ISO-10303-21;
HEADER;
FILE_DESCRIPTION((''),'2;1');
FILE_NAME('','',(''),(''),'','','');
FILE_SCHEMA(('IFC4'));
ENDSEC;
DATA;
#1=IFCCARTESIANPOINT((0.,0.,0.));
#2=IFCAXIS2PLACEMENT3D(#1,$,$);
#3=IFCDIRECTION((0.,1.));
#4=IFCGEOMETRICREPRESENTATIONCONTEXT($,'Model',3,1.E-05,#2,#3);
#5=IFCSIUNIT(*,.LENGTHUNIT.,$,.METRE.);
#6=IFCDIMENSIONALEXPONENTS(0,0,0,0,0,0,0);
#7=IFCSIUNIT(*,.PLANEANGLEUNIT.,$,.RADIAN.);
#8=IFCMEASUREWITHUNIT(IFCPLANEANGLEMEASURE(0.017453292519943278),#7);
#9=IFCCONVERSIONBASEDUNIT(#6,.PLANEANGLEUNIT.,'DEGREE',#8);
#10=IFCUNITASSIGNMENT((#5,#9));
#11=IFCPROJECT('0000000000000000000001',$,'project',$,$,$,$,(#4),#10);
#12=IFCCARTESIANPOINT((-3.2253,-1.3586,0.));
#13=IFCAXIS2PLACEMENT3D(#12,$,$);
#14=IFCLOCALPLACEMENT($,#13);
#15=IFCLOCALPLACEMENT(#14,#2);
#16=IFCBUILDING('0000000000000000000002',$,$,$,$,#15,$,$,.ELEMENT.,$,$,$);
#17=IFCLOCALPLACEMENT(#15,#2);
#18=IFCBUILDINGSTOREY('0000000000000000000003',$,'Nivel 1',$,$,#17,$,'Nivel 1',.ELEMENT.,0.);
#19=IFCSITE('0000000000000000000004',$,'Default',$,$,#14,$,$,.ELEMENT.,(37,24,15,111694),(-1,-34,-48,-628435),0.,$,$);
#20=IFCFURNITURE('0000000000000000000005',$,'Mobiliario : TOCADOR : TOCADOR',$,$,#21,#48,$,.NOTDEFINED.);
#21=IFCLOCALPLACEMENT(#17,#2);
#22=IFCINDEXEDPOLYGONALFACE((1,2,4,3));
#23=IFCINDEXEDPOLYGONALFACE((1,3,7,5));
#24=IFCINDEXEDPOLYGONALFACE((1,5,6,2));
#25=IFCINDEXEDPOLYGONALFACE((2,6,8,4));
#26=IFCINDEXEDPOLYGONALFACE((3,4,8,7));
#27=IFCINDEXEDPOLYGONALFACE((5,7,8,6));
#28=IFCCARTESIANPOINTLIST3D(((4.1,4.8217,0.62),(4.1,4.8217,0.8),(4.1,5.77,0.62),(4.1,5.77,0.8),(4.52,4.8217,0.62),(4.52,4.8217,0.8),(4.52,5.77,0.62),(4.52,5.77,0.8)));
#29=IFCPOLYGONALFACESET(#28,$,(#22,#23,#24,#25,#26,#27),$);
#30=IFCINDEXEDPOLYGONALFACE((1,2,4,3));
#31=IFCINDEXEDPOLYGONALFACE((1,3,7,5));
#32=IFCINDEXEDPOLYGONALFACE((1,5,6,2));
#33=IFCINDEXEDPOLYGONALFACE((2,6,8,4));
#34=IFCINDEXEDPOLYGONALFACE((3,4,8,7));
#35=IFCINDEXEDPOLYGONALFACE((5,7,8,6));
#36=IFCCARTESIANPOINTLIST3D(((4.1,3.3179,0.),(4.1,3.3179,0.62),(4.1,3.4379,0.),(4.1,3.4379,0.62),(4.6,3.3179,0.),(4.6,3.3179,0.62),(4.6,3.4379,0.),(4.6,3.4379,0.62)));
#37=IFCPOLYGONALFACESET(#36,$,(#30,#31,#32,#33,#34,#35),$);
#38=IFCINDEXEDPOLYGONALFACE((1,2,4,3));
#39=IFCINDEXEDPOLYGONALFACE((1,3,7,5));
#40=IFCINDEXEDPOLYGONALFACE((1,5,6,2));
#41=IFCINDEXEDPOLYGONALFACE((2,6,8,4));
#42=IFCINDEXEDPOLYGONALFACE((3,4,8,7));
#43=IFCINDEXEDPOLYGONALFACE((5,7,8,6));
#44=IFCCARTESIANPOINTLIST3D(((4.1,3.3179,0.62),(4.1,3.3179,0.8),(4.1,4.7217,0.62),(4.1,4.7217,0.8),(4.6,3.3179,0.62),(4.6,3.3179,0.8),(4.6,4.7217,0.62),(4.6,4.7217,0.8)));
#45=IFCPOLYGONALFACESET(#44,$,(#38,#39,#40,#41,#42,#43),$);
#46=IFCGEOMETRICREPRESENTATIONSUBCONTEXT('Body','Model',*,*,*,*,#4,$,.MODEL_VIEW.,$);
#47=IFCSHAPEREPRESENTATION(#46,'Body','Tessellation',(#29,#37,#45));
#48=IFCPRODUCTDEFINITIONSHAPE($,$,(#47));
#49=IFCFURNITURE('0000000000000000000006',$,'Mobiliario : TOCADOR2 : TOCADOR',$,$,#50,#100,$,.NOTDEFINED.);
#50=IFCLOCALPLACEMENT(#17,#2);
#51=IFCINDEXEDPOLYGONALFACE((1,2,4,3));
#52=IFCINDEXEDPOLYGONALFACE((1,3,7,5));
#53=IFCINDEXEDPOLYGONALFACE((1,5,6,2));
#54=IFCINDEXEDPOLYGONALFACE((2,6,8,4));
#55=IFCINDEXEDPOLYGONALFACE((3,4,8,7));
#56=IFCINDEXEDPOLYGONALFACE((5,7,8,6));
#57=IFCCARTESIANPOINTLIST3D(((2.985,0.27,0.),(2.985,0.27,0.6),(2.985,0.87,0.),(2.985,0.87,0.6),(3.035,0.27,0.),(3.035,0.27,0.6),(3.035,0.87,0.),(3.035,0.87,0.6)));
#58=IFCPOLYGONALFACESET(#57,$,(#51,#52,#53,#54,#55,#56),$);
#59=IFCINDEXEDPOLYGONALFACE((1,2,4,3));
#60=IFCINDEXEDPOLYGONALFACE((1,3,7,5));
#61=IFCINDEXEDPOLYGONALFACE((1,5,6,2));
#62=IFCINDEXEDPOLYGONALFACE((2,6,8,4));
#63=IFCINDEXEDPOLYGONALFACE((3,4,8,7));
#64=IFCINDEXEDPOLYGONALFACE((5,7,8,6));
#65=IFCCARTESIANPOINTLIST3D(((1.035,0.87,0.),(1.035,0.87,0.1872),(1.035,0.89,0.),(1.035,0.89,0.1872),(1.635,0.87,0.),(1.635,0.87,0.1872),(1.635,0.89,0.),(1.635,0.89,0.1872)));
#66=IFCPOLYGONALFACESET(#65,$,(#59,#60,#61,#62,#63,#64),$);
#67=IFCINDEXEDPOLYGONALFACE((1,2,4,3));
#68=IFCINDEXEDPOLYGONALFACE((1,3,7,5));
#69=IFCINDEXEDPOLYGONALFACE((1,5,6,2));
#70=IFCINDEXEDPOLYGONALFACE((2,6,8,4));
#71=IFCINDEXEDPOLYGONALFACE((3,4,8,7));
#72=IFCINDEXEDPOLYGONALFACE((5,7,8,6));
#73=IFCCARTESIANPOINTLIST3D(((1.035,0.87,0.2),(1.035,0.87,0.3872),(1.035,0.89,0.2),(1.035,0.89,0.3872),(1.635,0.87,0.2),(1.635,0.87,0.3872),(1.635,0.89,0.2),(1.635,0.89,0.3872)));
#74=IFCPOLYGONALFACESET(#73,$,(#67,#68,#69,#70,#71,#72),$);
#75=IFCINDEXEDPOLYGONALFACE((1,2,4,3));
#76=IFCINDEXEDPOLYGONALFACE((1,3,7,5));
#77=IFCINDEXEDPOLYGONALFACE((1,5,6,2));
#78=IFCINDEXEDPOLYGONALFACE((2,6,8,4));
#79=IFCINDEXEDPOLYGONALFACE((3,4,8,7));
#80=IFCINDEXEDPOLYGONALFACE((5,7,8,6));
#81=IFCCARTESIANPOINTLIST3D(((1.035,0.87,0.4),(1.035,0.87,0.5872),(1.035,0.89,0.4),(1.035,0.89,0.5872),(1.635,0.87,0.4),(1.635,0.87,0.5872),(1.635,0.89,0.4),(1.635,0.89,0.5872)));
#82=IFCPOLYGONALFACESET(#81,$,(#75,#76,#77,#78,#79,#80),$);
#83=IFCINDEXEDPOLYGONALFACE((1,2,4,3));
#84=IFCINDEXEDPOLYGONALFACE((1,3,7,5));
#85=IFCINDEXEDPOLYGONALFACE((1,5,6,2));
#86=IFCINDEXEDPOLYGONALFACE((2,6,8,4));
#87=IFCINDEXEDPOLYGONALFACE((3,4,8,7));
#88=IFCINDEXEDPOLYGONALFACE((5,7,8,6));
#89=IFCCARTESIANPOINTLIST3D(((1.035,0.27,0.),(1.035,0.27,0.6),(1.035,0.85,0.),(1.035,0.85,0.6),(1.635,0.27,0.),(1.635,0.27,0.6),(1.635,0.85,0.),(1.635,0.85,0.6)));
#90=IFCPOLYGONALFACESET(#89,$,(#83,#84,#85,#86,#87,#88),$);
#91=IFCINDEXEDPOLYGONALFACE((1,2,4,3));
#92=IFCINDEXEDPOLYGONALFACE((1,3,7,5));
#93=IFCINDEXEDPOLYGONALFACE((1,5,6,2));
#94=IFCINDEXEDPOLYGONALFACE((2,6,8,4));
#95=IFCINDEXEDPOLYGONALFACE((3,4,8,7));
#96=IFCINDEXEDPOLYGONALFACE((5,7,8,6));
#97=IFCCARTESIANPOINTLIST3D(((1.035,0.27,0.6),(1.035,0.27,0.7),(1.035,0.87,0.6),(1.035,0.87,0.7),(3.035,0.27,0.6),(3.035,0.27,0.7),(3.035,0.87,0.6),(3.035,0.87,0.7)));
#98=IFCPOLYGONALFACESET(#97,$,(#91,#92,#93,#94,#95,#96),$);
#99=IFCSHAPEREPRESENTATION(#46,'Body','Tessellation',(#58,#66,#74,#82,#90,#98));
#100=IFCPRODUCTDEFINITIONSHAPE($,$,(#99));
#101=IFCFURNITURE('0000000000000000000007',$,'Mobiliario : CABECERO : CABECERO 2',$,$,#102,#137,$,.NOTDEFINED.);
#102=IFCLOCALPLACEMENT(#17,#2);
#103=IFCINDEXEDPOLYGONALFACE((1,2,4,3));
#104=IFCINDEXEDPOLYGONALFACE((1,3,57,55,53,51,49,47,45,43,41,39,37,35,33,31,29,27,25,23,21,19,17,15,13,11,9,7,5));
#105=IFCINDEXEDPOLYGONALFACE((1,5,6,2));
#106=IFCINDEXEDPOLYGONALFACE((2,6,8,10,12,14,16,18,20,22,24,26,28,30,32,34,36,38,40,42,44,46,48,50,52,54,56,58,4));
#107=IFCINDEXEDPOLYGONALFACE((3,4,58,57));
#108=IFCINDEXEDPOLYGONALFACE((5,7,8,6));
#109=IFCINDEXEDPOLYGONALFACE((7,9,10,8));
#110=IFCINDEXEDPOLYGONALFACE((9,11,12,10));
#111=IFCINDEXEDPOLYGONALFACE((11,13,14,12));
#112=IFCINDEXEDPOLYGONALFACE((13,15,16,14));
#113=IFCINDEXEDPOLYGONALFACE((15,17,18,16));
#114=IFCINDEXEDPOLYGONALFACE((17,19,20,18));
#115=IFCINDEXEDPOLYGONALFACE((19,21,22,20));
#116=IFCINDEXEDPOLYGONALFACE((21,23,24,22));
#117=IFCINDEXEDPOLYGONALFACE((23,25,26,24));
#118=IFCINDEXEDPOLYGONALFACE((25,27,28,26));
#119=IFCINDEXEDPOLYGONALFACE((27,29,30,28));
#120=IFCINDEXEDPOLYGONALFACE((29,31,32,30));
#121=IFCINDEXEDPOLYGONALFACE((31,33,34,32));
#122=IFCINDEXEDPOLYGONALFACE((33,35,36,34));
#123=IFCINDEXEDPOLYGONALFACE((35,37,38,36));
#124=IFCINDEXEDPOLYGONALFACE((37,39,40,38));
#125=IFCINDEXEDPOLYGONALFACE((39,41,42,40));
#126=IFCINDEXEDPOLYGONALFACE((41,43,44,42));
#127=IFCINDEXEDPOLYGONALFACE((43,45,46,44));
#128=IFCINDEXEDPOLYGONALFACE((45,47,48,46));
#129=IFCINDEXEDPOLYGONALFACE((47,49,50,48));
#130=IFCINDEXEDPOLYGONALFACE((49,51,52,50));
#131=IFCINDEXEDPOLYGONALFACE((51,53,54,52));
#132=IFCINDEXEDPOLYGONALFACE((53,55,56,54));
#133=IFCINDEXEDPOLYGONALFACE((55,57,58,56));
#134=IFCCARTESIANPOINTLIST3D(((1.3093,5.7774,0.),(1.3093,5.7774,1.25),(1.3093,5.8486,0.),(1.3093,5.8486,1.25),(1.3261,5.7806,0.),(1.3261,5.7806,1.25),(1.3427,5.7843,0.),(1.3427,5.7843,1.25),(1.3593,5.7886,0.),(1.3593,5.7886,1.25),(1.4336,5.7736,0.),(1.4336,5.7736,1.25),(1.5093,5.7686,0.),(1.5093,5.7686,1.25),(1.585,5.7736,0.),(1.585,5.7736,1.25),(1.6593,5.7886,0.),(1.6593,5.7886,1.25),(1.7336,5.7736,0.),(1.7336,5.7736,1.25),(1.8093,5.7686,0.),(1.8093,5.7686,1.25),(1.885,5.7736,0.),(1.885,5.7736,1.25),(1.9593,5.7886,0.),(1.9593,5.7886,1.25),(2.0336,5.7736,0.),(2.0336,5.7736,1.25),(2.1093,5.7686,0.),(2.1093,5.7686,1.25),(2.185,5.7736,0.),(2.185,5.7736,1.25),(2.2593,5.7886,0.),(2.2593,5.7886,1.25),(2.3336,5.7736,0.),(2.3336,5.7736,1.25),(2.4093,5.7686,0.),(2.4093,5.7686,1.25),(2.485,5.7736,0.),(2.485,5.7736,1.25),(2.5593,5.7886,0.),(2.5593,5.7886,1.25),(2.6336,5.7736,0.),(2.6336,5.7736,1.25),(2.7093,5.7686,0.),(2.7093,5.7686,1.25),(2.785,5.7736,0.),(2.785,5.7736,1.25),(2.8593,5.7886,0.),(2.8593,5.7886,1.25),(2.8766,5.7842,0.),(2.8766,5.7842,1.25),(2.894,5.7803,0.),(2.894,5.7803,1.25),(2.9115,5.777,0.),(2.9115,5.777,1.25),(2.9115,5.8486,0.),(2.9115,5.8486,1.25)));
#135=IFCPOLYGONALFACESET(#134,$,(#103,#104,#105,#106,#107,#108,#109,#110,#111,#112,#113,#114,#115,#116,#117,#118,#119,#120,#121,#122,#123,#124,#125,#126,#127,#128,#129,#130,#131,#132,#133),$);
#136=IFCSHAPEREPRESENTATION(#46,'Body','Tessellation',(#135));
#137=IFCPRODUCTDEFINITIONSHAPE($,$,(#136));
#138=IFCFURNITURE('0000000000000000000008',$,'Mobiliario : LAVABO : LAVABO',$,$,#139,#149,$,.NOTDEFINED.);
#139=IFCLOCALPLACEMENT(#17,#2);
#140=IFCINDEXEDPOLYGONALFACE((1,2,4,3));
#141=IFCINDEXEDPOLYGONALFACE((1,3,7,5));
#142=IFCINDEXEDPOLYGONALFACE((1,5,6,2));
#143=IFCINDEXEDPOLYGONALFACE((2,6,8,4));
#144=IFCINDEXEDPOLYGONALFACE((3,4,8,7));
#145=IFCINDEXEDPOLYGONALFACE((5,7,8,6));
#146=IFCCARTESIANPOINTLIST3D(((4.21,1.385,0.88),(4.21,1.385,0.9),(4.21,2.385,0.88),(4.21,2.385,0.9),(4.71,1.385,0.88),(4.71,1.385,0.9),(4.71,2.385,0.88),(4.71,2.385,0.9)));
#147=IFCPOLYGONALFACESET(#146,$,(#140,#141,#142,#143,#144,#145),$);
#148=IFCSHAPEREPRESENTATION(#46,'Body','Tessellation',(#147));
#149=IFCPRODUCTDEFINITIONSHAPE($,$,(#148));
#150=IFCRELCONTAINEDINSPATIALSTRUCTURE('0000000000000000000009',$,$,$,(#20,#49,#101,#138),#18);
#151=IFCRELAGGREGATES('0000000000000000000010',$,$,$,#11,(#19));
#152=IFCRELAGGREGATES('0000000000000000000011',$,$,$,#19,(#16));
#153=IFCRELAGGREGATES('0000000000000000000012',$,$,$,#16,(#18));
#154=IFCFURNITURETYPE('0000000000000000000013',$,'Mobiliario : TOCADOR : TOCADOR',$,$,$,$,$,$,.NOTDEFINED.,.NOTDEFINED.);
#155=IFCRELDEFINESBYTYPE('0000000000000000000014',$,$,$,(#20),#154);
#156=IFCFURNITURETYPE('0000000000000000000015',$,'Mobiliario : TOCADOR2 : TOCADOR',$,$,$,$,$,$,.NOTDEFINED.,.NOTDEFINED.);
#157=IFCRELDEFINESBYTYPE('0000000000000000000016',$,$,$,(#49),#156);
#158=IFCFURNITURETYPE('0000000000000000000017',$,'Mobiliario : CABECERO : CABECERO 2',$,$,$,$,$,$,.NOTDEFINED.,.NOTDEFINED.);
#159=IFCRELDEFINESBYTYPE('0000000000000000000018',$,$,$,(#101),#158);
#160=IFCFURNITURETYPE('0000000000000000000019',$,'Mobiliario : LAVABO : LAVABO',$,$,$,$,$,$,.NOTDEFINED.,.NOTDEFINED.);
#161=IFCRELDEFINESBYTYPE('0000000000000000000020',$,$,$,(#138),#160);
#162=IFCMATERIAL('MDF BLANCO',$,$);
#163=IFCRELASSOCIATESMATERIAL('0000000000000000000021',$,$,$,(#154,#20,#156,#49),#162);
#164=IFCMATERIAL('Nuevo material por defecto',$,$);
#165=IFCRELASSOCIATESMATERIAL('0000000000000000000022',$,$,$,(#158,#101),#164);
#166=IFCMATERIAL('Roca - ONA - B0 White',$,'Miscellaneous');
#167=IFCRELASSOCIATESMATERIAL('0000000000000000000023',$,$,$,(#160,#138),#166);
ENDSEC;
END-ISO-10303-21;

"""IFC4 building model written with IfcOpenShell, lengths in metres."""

from ifc_helpers import new_model, entity, si_unit, converted_unit, direction, frame, origin, place, context, subcontext, project, spatial, line, arc, indexed_curve, outline, extrude, source, transform, mapped, material, type_object, type_shapes, element, save


model = new_model("IFC4")

# Units and contexts
model_context = context("Model", 3, precision=1e-05, world=origin(), true_north=direction((0.0, 1.0)))
body_context = subcontext(model_context, "Body", "Model", "MODEL_VIEW")
ifc_project = project(units=[si_unit("LENGTHUNIT", "METRE"), converted_unit("PLANEANGLEUNIT", "DEGREE", entity("IfcPlaneAngleMeasure", 0.017453292519943278), si_unit("PLANEANGLEUNIT", "RADIAN"), dimensions=[0, 0, 0, 0, 0, 0, 0])], contexts=[model_context])

# Site, building, storey
site_placement = place(None, frame((-3.2253, -1.3586, 0.0)))
site = spatial("IfcSite", under=ifc_project, at=site_placement, Name="Default", CompositionType="ELEMENT", RefLatitude=(37, 24, 15, 111694), RefLongitude=(-1, -34, -48, -628435), RefElevation=0.0)
building_placement = place(site_placement, origin())
building = spatial("IfcBuilding", under=site, at=building_placement, CompositionType="ELEMENT")
storey_placement = place(building_placement, origin())
storey = spatial("IfcBuildingStorey", under=building, at=storey_placement, Name="Nivel 1", LongName="Nivel 1", CompositionType="ELEMENT", Elevation=0.0)

# Furniture
ifc_material_1 = material(Name="MDF BLANCO")
furniture_type_1 = type_object("IfcFurnitureType", Name="Mobiliario : TOCADOR : TOCADOR", AssemblyPlace="NOTDEFINED", PredefinedType="NOTDEFINED", material=ifc_material_1)
shared_shape_1 = source(origin(), body_context, "Body", "SweptSolid", [
    extrude(outline(indexed_curve([(-0.21, -0.4741), (0.21, -0.4741), (0.21, 0.4741), (-0.21, 0.4741), (-0.21, -0.4741)], self_intersect=False)), frame((1.0847, 3.9373, 0.62), z_axis=(0.0, 0.0, 1.0), x_axis=(-1.0, 0.0, 0.0)), (0.0, 0.0, 1.0), 0.18),
    extrude(outline(indexed_curve([(-0.06, -0.25), (0.06, -0.25), (0.06, 0.25), (-0.06, 0.25), (-0.06, -0.25)], self_intersect=False)), frame((1.1247, 2.0193, 0.0), z_axis=(0.0, 0.0, 1.0), x_axis=(0.0, 1.0, 0.0)), (0.0, 0.0, 1.0), 0.62),
    extrude(outline(indexed_curve([(-0.7019, -0.25), (0.7019, -0.25), (0.7019, 0.25), (-0.7019, 0.25), (-0.7019, -0.25)], self_intersect=False)), frame((1.1247, 2.6612, 0.62), z_axis=(0.0, 0.0, 1.0), x_axis=(0.0, 1.0, 0.0)), (0.0, 0.0, 1.0), 0.18),
])
type_shapes(furniture_type_1, [shared_shape_1])
furniture_1_placement = place(storey_placement, frame((3.2253, 1.3586, 0.0)))
element("IfcFurniture", 1, at=furniture_1_placement, inside=storey, type_object=furniture_type_1, material=ifc_material_1, Name="Mobiliario : TOCADOR : TOCADOR", PredefinedType="NOTDEFINED", context=body_context, shape_type="MappedRepresentation", body=[
    mapped(shared_shape_1, transform((0.0, 0.0, 0.0), scale=1.0)),
])
furniture_type_2 = type_object("IfcFurnitureType", Name="Mobiliario : TOCADOR2 : TOCADOR", AssemblyPlace="NOTDEFINED", PredefinedType="NOTDEFINED", material=ifc_material_1)
shared_shape_2 = source(origin(), body_context, "Body", "SweptSolid", [
    extrude(outline(indexed_curve([(-0.025, -0.3), (0.025, -0.3), (0.025, 0.3), (-0.025, 0.3), (-0.025, -0.3)], self_intersect=False)), frame((-0.3803, -0.7886, 0.0)), (0.0, 0.0, 1.0), 0.6),
    extrude(outline(indexed_curve([(-0.3, -0.01), (0.3, -0.01), (0.3, 0.01), (-0.3, 0.01), (-0.3, -0.01)], self_intersect=False)), frame((-2.0553, -0.4786, 0.0), z_axis=(0.0, 0.0, 1.0), x_axis=(-1.0, 0.0, 0.0)), (0.0, 0.0, 1.0), 0.1872),
    extrude(outline(indexed_curve([(-0.3, -0.01), (0.3, -0.01), (0.3, 0.01), (-0.3, 0.01), (-0.3, -0.01)], self_intersect=False)), frame((-2.0553, -0.4786, 0.2), z_axis=(0.0, 0.0, 1.0), x_axis=(-1.0, 0.0, 0.0)), (0.0, 0.0, 1.0), 0.1872),
    extrude(outline(indexed_curve([(-0.3, -0.01), (0.3, -0.01), (0.3, 0.01), (-0.3, 0.01), (-0.3, -0.01)], self_intersect=False)), frame((-2.0553, -0.4786, 0.4), z_axis=(0.0, 0.0, 1.0), x_axis=(-1.0, 0.0, 0.0)), (0.0, 0.0, 1.0), 0.1872),
    extrude(outline(indexed_curve([(-0.3, -0.29), (0.3, -0.29), (0.3, 0.29), (-0.3, 0.29), (-0.3, -0.29)], self_intersect=False)), frame((-2.0553, -0.7986, 0.0), z_axis=(0.0, 0.0, 1.0), x_axis=(-1.0, 0.0, 0.0)), (0.0, 0.0, 1.0), 0.6),
    extrude(outline(indexed_curve([(-0.3, -1.0), (0.3, -1.0), (0.3, 1.0), (-0.3, 1.0), (-0.3, -1.0)], self_intersect=False)), frame((-1.3553, -0.7886, 0.6), z_axis=(0.0, 0.0, 1.0), x_axis=(0.0, -1.0, 0.0)), (0.0, 0.0, 1.0), 0.1),
])
type_shapes(furniture_type_2, [shared_shape_2])
furniture_2_placement = place(storey_placement, frame((3.3903, 1.3586, 0.0)))
element("IfcFurniture", 2, at=furniture_2_placement, inside=storey, type_object=furniture_type_2, material=ifc_material_1, Name="Mobiliario : TOCADOR2 : TOCADOR", PredefinedType="NOTDEFINED", context=body_context, shape_type="MappedRepresentation", body=[
    mapped(shared_shape_2, transform((0.0, 0.0, 0.0), scale=1.0)),
])
ifc_material_2 = material(Name="Nuevo material por defecto")
furniture_type_3 = type_object("IfcFurnitureType", Name="Mobiliario : CABECERO : CABECERO 2", AssemblyPlace="NOTDEFINED", PredefinedType="NOTDEFINED", material=ifc_material_2)
shared_shape_3 = source(origin(), body_context, "Body", "SweptSolid", [
    extrude(outline(indexed_curve([(-0.8018, -0.0503), (0.8004, -0.0503), (0.8004, 0.0209), (0.7753, 0.0159), (0.7504, 0.0097), (0.6004, 0.0297), (0.4504, 0.0097), (0.3004, 0.0297), (0.1504, 0.0097), (0.0004, 0.0297), (-0.1496, 0.0097), (-0.2996, 0.0297), (-0.4496, 0.0097), (-0.5996, 0.0297), (-0.7496, 0.0097), (-0.7755, 0.0161), (-0.8018, 0.0213)], segments=[line(1, 2, 3), arc(3, 4, 5), arc(5, 6, 7), arc(7, 8, 9), arc(9, 10, 11), arc(11, 12, 13), arc(13, 14, 15), arc(15, 16, 17), line(17, 1)], self_intersect=False)), frame((0.0004, -0.0103, 0.0), z_axis=(0.0, 0.0, 1.0), x_axis=(-1.0, 0.0, 0.0)), (0.0, 0.0, 1.0), 1.25),
])
type_shapes(furniture_type_3, [shared_shape_3])
furniture_3_placement = place(storey_placement, frame((2.1093, 5.8086, 0.0)))
element("IfcFurniture", 3, at=furniture_3_placement, inside=storey, type_object=furniture_type_3, material=ifc_material_2, Name="Mobiliario : CABECERO : CABECERO 2", PredefinedType="NOTDEFINED", context=body_context, shape_type="MappedRepresentation", body=[
    mapped(shared_shape_3, transform((0.0, 0.0, 0.0), scale=1.0)),
])
ifc_material_3 = material(Name="Roca - ONA - B0 White", Category="Miscellaneous")
furniture_type_4 = type_object("IfcFurnitureType", Name="Mobiliario : LAVABO : LAVABO", AssemblyPlace="NOTDEFINED", PredefinedType="NOTDEFINED", material=ifc_material_3)
shared_shape_4 = source(origin(), body_context, "Body", "SweptSolid", [
    extrude(outline(indexed_curve([(-0.25, -0.5), (0.25, -0.5), (0.25, 0.5), (-0.25, 0.5), (-0.25, -0.5)], self_intersect=False)), frame((1.2347, 0.5264, 0.88), z_axis=(0.0, 0.0, 1.0), x_axis=(-1.0, 0.0, 0.0)), (0.0, 0.0, 1.0), 0.02),
])
type_shapes(furniture_type_4, [shared_shape_4])
furniture_4_placement = place(storey_placement, frame((3.2253, 1.3586, 0.0)))
element("IfcFurniture", 4, at=furniture_4_placement, inside=storey, type_object=furniture_type_4, material=ifc_material_3, Name="Mobiliario : LAVABO : LAVABO", PredefinedType="NOTDEFINED", context=body_context, shape_type="MappedRepresentation", body=[
    mapped(shared_shape_4, transform((0.0, 0.0, 0.0), scale=1.0)),
])

save(model, "model.ifc")
